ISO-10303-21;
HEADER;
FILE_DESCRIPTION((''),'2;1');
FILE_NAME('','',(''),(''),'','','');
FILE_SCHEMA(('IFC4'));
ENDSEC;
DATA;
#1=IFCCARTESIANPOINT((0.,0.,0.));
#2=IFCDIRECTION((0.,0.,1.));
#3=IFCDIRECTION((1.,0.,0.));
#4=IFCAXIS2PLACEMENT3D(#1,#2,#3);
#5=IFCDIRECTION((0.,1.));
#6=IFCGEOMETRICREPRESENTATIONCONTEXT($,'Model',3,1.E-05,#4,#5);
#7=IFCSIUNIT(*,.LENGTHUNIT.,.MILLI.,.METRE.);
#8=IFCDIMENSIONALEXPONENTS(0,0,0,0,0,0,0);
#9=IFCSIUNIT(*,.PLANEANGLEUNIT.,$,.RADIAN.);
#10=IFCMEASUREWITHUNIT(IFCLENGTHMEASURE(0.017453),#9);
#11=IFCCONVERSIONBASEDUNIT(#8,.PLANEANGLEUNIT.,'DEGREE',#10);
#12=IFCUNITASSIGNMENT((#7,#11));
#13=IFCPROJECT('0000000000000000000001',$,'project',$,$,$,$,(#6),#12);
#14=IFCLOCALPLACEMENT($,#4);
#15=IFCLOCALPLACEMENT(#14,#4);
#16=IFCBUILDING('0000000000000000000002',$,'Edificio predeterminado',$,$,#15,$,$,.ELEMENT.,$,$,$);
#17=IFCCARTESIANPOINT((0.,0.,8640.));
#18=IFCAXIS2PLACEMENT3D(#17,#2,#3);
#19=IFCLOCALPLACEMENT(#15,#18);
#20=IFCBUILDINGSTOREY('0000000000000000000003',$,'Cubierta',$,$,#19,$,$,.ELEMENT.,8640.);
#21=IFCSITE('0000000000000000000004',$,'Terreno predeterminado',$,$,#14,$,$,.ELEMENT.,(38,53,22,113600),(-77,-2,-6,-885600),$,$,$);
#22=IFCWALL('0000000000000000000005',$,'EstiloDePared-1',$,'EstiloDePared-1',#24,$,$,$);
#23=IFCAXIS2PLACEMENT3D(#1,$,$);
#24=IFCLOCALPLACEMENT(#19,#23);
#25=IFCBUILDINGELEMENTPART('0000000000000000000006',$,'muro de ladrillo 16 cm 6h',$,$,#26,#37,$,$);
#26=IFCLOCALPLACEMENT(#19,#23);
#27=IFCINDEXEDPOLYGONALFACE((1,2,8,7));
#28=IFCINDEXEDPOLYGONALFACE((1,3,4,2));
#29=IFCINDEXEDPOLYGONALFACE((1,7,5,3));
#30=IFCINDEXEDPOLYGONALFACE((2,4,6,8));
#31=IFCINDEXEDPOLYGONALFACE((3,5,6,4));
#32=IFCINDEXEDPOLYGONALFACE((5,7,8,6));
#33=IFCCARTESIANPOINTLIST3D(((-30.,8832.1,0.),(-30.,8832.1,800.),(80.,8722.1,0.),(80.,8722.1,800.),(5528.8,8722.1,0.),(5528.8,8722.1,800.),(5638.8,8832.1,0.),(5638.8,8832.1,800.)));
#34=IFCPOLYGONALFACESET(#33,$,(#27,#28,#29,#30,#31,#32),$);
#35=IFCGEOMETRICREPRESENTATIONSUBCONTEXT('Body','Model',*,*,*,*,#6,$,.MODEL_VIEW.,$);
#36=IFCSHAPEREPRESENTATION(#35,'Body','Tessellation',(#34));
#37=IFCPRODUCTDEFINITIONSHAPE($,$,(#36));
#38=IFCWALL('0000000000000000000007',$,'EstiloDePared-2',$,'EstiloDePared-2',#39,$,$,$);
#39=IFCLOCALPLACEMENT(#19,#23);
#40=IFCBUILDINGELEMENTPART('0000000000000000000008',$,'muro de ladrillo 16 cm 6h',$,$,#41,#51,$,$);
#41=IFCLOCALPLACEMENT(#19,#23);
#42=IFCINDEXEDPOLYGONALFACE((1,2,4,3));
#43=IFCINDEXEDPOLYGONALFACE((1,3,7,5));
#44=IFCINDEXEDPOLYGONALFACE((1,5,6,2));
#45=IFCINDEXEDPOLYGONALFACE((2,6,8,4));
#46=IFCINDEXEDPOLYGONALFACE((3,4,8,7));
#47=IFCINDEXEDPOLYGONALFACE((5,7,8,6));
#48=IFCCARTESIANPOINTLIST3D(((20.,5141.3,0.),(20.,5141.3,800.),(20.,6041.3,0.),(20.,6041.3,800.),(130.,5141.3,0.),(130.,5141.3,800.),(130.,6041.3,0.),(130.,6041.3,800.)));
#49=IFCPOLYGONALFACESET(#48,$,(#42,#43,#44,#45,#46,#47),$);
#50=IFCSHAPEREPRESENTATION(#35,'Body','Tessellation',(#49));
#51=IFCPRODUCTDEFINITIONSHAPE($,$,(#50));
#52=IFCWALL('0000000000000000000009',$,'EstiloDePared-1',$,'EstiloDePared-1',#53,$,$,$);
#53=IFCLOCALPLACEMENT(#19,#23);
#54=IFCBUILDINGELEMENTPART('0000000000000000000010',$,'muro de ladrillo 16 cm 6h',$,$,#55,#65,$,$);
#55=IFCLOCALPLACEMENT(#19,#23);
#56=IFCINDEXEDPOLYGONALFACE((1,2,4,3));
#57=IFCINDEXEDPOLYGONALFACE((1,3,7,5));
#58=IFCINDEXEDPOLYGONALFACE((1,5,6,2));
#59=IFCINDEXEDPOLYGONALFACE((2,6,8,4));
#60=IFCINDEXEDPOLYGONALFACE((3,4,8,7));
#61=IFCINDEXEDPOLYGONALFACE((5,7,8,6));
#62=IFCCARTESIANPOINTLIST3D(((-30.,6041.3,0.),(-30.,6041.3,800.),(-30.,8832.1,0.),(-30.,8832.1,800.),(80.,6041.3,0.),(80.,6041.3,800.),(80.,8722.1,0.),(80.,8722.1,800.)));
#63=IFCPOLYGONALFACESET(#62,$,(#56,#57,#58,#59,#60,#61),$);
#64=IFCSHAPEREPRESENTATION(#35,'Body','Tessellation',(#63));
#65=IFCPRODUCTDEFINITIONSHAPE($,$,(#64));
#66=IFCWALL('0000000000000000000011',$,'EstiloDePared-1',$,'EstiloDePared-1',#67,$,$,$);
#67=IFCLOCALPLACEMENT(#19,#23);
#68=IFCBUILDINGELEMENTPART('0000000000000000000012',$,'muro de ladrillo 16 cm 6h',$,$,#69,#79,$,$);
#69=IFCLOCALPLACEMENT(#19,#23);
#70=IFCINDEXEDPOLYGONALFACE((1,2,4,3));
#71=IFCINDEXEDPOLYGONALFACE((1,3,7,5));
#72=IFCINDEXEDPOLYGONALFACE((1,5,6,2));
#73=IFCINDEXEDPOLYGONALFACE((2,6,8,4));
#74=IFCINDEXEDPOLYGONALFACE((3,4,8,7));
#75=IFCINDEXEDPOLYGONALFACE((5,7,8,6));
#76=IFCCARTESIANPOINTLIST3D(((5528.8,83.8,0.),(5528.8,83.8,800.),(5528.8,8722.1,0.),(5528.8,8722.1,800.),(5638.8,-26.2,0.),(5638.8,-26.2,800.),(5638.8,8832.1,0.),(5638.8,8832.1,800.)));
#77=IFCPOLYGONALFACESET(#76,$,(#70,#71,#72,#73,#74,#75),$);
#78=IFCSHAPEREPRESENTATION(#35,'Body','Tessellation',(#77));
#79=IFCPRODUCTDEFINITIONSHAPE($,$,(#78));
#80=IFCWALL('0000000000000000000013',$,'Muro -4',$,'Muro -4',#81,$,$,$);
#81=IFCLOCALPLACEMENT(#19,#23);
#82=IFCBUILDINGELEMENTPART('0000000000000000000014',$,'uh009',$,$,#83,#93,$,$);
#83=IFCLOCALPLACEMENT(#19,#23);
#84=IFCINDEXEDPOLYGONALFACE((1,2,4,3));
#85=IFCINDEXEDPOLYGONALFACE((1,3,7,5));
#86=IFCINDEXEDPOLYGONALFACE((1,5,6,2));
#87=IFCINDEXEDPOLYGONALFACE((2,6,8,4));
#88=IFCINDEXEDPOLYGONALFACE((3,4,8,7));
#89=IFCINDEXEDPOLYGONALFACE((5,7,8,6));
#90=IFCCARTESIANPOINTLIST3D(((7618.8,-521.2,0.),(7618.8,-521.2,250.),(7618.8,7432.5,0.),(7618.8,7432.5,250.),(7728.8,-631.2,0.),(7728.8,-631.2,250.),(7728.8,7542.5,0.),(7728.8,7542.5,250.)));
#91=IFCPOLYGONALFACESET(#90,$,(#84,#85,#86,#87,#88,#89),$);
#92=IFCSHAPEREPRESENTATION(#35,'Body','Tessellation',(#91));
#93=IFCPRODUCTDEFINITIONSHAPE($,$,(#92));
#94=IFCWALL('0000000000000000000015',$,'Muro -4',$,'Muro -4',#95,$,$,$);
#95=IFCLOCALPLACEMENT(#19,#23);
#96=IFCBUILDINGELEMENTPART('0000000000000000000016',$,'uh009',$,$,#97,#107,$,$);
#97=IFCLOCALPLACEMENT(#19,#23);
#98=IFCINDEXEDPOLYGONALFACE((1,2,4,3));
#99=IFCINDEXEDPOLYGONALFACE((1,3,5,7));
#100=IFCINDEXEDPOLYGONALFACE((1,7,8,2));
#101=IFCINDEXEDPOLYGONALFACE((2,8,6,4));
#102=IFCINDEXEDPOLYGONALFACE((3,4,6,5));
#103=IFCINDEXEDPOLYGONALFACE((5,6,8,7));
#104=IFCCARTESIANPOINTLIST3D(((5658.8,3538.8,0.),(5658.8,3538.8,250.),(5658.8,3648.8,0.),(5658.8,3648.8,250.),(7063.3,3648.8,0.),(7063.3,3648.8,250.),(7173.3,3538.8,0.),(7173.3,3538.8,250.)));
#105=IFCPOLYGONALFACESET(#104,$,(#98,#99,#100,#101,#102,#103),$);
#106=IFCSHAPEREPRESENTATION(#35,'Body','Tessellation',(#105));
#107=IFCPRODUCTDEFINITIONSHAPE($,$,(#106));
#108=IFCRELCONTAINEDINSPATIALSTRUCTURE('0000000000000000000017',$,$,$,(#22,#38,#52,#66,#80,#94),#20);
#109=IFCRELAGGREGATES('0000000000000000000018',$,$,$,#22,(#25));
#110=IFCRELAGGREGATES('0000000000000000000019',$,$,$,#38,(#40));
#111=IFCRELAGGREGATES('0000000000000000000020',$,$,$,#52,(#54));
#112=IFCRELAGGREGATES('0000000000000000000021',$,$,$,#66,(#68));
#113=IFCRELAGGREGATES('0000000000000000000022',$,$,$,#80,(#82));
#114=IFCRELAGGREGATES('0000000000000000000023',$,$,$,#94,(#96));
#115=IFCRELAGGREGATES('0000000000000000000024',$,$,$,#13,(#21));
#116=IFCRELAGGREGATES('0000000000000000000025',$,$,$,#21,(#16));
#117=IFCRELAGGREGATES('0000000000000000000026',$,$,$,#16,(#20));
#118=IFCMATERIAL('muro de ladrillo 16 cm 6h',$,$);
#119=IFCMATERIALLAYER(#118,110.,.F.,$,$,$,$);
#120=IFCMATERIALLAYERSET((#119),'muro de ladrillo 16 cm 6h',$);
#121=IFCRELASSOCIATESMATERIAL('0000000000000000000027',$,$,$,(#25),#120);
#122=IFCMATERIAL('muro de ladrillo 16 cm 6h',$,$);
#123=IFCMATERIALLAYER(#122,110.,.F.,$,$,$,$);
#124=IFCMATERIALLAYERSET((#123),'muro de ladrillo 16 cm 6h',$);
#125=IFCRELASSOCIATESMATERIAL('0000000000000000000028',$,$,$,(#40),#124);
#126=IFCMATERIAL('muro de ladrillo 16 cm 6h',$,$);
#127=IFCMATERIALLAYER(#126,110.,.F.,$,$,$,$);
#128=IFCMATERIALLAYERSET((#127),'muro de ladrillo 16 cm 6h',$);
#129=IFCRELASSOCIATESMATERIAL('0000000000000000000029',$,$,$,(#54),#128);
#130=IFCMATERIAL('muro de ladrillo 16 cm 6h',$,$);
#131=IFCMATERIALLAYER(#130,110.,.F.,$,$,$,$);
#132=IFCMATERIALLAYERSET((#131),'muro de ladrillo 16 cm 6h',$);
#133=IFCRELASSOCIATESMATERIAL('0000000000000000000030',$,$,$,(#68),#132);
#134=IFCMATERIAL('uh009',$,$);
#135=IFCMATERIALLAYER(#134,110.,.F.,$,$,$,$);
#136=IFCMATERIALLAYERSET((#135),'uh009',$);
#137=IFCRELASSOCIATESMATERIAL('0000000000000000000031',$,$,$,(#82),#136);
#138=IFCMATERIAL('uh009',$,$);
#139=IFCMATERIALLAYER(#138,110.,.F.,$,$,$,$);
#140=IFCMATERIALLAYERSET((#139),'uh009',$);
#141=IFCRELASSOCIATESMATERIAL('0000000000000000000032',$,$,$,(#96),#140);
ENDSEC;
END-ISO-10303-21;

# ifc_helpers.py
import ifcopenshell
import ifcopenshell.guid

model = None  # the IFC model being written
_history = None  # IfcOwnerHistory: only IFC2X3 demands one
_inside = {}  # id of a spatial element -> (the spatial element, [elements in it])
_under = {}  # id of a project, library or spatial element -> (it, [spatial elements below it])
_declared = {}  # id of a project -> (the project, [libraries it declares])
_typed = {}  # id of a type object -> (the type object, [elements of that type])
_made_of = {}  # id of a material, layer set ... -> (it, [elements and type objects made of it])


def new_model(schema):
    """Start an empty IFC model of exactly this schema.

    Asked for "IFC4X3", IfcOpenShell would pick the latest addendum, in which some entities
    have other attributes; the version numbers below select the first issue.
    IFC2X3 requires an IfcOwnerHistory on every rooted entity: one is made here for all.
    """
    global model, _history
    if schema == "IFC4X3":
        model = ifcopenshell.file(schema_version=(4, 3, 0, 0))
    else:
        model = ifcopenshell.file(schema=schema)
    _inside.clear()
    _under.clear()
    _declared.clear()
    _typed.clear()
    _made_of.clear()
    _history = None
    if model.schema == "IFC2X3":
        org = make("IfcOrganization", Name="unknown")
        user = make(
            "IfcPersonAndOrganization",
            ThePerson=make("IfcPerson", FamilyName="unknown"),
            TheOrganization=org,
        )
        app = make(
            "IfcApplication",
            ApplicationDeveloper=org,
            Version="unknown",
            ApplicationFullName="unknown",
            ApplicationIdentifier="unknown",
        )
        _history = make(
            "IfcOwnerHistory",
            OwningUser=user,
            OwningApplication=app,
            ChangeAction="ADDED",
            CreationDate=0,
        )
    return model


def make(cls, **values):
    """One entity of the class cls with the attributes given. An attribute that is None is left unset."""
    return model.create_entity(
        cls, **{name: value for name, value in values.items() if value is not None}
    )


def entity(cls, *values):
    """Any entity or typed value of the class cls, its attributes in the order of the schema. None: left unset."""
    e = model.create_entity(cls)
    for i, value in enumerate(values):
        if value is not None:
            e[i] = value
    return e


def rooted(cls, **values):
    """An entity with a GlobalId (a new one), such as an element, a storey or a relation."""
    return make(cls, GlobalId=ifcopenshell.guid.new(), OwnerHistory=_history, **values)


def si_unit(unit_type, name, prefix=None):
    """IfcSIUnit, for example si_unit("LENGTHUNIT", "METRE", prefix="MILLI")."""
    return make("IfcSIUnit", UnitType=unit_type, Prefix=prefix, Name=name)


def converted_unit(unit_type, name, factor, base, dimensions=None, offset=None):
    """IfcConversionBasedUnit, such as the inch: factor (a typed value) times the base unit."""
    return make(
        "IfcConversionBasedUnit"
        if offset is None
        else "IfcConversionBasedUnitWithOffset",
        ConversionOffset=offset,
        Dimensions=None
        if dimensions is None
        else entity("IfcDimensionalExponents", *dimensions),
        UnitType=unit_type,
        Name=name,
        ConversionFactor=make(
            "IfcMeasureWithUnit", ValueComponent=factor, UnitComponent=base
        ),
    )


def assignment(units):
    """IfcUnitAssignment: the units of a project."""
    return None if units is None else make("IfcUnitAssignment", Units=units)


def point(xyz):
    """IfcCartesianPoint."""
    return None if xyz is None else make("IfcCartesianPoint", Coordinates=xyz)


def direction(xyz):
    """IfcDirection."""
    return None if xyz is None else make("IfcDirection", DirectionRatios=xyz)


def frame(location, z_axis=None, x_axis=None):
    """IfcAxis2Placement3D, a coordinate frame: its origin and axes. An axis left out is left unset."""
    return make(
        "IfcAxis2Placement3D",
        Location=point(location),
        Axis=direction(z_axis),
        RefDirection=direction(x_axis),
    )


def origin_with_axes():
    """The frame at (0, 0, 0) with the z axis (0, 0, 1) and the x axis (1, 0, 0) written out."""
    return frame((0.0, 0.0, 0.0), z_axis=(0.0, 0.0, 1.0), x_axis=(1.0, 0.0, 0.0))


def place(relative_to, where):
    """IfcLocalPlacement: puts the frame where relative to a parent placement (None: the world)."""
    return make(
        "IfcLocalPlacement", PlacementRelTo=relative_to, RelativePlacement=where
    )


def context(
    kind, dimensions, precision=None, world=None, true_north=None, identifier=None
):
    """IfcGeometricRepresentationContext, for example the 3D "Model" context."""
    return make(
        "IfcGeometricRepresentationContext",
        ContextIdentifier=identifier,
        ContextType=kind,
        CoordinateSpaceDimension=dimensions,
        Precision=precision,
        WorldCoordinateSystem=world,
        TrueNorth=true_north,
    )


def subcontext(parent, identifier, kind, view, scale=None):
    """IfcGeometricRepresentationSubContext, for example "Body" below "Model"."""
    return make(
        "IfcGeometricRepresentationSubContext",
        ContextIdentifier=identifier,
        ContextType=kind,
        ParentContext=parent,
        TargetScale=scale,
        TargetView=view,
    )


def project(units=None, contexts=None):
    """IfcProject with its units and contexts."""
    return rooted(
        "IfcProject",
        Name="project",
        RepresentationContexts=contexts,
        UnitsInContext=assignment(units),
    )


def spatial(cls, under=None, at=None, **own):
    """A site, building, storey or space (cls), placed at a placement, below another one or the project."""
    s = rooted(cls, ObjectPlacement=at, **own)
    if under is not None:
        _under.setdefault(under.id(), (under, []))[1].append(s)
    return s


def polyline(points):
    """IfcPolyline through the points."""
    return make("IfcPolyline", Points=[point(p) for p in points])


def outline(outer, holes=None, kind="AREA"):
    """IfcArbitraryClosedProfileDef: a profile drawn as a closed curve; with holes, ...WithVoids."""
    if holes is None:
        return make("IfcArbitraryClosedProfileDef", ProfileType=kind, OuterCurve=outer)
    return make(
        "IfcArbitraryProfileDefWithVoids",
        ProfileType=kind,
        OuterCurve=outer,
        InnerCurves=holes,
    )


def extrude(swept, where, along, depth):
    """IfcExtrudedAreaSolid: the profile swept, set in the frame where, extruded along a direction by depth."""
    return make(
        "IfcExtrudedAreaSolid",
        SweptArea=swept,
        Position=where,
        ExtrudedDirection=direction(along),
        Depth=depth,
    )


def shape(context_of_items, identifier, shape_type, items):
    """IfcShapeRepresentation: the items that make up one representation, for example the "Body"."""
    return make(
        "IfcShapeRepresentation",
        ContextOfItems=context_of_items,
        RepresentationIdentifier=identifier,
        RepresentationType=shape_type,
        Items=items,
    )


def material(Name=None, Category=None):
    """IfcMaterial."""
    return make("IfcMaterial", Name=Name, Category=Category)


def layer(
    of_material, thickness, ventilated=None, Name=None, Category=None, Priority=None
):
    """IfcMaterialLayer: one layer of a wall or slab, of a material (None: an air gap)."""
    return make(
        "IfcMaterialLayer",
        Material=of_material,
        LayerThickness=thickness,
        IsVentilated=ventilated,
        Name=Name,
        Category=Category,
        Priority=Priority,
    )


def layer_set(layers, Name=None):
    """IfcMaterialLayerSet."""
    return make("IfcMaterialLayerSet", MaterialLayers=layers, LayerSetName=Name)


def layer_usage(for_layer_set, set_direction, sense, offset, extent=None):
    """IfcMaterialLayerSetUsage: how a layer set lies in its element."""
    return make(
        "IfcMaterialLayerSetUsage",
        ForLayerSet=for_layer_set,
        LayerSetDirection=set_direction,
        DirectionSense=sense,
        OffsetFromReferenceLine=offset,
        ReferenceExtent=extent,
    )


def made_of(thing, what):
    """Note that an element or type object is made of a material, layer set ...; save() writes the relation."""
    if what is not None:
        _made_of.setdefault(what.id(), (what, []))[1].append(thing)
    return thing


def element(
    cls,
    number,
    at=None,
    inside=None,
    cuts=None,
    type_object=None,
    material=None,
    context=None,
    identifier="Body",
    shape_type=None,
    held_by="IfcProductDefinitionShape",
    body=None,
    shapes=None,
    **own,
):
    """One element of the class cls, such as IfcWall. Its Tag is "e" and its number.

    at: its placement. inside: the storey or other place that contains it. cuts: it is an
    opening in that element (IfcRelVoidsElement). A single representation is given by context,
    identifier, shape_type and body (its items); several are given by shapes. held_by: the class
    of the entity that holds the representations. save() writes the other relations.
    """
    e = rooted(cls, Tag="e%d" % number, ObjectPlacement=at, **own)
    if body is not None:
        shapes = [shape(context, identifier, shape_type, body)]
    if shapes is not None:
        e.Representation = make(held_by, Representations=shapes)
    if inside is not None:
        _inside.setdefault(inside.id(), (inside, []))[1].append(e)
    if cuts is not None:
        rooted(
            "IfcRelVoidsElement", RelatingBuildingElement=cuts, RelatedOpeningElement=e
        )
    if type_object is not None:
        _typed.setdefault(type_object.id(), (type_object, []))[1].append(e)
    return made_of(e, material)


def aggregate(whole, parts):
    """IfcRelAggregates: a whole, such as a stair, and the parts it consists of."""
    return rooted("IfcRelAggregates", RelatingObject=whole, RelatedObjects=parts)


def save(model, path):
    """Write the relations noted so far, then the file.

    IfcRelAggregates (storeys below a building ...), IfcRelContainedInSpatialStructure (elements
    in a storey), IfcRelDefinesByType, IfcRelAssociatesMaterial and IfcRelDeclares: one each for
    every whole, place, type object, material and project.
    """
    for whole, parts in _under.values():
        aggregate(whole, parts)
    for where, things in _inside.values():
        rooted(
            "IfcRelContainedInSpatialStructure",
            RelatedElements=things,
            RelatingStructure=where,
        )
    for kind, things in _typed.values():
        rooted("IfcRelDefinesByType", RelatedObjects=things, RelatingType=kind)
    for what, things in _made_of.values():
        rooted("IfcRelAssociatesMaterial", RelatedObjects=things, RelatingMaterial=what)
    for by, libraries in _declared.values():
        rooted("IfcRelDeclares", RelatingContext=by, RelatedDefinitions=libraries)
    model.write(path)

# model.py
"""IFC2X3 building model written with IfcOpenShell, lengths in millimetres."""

from ifc_helpers import new_model, entity, si_unit, converted_unit, direction, frame, origin_with_axes, place, context, subcontext, project, spatial, polyline, outline, extrude, material, layer, layer_set, layer_usage, element, aggregate, save


model = new_model("IFC2X3")

# Units and contexts
model_context = context("Model", 3, precision=1e-05, world=origin_with_axes(), true_north=direction((0.0, 1.0)))
body_context = subcontext(model_context, "Body", "Model", "MODEL_VIEW")
ifc_project = project(units=[si_unit("LENGTHUNIT", "METRE", prefix="MILLI"), converted_unit("PLANEANGLEUNIT", "DEGREE", entity("IfcLengthMeasure", 0.017453), si_unit("PLANEANGLEUNIT", "RADIAN"), dimensions=[0, 0, 0, 0, 0, 0, 0])], contexts=[model_context])

# Site, building, storey
site_placement = place(None, origin_with_axes())
site = spatial("IfcSite", under=ifc_project, at=site_placement, Name="Terreno predeterminado", CompositionType="ELEMENT", RefLatitude=(38, 53, 22, 113600), RefLongitude=(-77, -2, -6, -885600))
building_placement = place(site_placement, origin_with_axes())
building = spatial("IfcBuilding", under=site, at=building_placement, Name="Edificio predeterminado", CompositionType="ELEMENT")
storey_placement = place(building_placement, frame((0.0, 0.0, 8640.0), z_axis=(0.0, 0.0, 1.0), x_axis=(1.0, 0.0, 0.0)))
storey = spatial("IfcBuildingStorey", under=building, at=storey_placement, Name="Cubierta", CompositionType="ELEMENT", Elevation=8640.0)

# Wall, building element part
wall_1_placement = place(storey_placement, frame((25.0, 8777.1, 0.0), z_axis=(0.0, 0.0, 1.0), x_axis=(1.0, 0.0, 0.0)))
wall_1 = element("IfcWall", 1, at=wall_1_placement, inside=storey, Name="EstiloDePared-1", ObjectType="EstiloDePared-1")
ifc_material_1 = material(Name="muro de ladrillo 16 cm 6h")
ifc_layer_1 = layer(ifc_material_1, 110.0, ventilated=False)
ifc_layer_set_1 = layer_set([ifc_layer_1], Name="muro de ladrillo 16 cm 6h")
ifc_layer_usage_1 = layer_usage(ifc_layer_set_1, "AXIS2", "NEGATIVE", -55.0)
building_element_part_1_placement = place(wall_1_placement, origin_with_axes())
building_element_part_1 = element("IfcBuildingElementPart", 2, at=building_element_part_1_placement, material=ifc_layer_usage_1, Name="muro de ladrillo 16 cm 6h", context=body_context, shape_type="SweptSolid", body=[
    extrude(outline(polyline([(5613.8, 55.0), (5503.8, -55.0), (55.0, -55.0), (-55.0, 55.0), (5613.8, 55.0)])), origin_with_axes(), (0.0, 0.0, 1.0), 800.0),
])
aggregate(wall_1, [building_element_part_1])

# Walls, building element parts
wall_2_placement = place(storey_placement, frame((75.0, 5141.3, 0.0), z_axis=(0.0, 0.0, 1.0), x_axis=(0.0, 1.0, 0.0)))
wall_2 = element("IfcWall", 3, at=wall_2_placement, inside=storey, Name="EstiloDePared-2", ObjectType="EstiloDePared-2")
ifc_material_2 = material(Name="muro de ladrillo 16 cm 6h")
ifc_layer_2 = layer(ifc_material_2, 110.0, ventilated=False)
ifc_layer_set_2 = layer_set([ifc_layer_2], Name="muro de ladrillo 16 cm 6h")
ifc_layer_usage_2 = layer_usage(ifc_layer_set_2, "AXIS2", "NEGATIVE", -55.0)
building_element_part_2_placement = place(wall_2_placement, origin_with_axes())
building_element_part_2 = element("IfcBuildingElementPart", 4, at=building_element_part_2_placement, material=ifc_layer_usage_2, Name="muro de ladrillo 16 cm 6h", context=body_context, shape_type="SweptSolid", body=[
    extrude(outline(polyline([(900.0, 55.0), (900.0, -55.0), (0.0, -55.0), (0.0, 55.0), (900.0, 55.0)])), origin_with_axes(), (0.0, 0.0, 1.0), 800.0),
])
aggregate(wall_2, [building_element_part_2])
wall_3_placement = place(storey_placement, frame((25.0, 6041.3, 0.0), z_axis=(0.0, 0.0, 1.0), x_axis=(0.0, 1.0, 0.0)))
wall_3 = element("IfcWall", 5, at=wall_3_placement, inside=storey, Name="EstiloDePared-1", ObjectType="EstiloDePared-1")
ifc_material_3 = material(Name="muro de ladrillo 16 cm 6h")
ifc_layer_3 = layer(ifc_material_3, 110.0, ventilated=False)
ifc_layer_set_3 = layer_set([ifc_layer_3], Name="muro de ladrillo 16 cm 6h")
ifc_layer_usage_3 = layer_usage(ifc_layer_set_3, "AXIS2", "NEGATIVE", -55.0)
building_element_part_3_placement = place(wall_3_placement, origin_with_axes())
building_element_part_3 = element("IfcBuildingElementPart", 6, at=building_element_part_3_placement, material=ifc_layer_usage_3, Name="muro de ladrillo 16 cm 6h", context=body_context, shape_type="SweptSolid", body=[
    extrude(outline(polyline([(2790.8, 55.0), (2680.8, -55.0), (0.0, -55.0), (0.0, 55.0), (2790.8, 55.0)])), origin_with_axes(), (0.0, 0.0, 1.0), 800.0),
])
aggregate(wall_3, [building_element_part_3])
wall_4_placement = place(storey_placement, frame((5583.8, 8777.1, 0.0), z_axis=(0.0, 0.0, 1.0), x_axis=(0.0, -1.0, 0.0)))
wall_4 = element("IfcWall", 7, at=wall_4_placement, inside=storey, Name="EstiloDePared-1", ObjectType="EstiloDePared-1")
ifc_material_4 = material(Name="muro de ladrillo 16 cm 6h")
ifc_layer_4 = layer(ifc_material_4, 110.0, ventilated=False)
ifc_layer_set_4 = layer_set([ifc_layer_4], Name="muro de ladrillo 16 cm 6h")
ifc_layer_usage_4 = layer_usage(ifc_layer_set_4, "AXIS2", "NEGATIVE", -55.0)
building_element_part_4_placement = place(wall_4_placement, origin_with_axes())
building_element_part_4 = element("IfcBuildingElementPart", 8, at=building_element_part_4_placement, material=ifc_layer_usage_4, Name="muro de ladrillo 16 cm 6h", context=body_context, shape_type="SweptSolid", body=[
    extrude(outline(polyline([(8803.3, 55.0), (8693.3, -55.0), (55.0, -55.0), (-55.0, 55.0), (8803.3, 55.0)])), origin_with_axes(), (0.0, 0.0, 1.0), 800.0),
])
aggregate(wall_4, [building_element_part_4])
wall_5_placement = place(storey_placement, frame((7673.8, 7487.5, 0.0), z_axis=(0.0, 0.0, 1.0), x_axis=(0.0, -1.0, 0.0)))
wall_5 = element("IfcWall", 9, at=wall_5_placement, inside=storey, Name="Muro -4", ObjectType="Muro -4")
ifc_material_5 = material(Name="uh009")
ifc_layer_5 = layer(ifc_material_5, 110.0, ventilated=False)
ifc_layer_set_5 = layer_set([ifc_layer_5], Name="uh009")
ifc_layer_usage_5 = layer_usage(ifc_layer_set_5, "AXIS2", "NEGATIVE", -55.0)
building_element_part_5_placement = place(wall_5_placement, origin_with_axes())
building_element_part_5 = element("IfcBuildingElementPart", 10, at=building_element_part_5_placement, material=ifc_layer_usage_5, Name="uh009", context=body_context, shape_type="SweptSolid", body=[
    extrude(outline(polyline([(8118.7, 55.0), (8008.7, -55.0), (55.0, -55.0), (-55.0, 55.0), (8118.7, 55.0)])), origin_with_axes(), (0.0, 0.0, 1.0), 250.0),
])
aggregate(wall_5, [building_element_part_5])
wall_6_placement = place(storey_placement, frame((7118.3, 3593.8, 0.0), z_axis=(0.0, 0.0, 1.0), x_axis=(-1.0, 0.0, 0.0)))
wall_6 = element("IfcWall", 11, at=wall_6_placement, inside=storey, Name="Muro -4", ObjectType="Muro -4")
ifc_material_6 = material(Name="uh009")
ifc_layer_6 = layer(ifc_material_6, 110.0, ventilated=False)
ifc_layer_set_6 = layer_set([ifc_layer_6], Name="uh009")
ifc_layer_usage_6 = layer_usage(ifc_layer_set_6, "AXIS2", "NEGATIVE", -55.0)
building_element_part_6_placement = place(wall_6_placement, origin_with_axes())
building_element_part_6 = element("IfcBuildingElementPart", 12, at=building_element_part_6_placement, material=ifc_layer_usage_6, Name="uh009", context=body_context, shape_type="SweptSolid", body=[
    extrude(outline(polyline([(1459.4, 55.0), (1459.4, -55.0), (55.0, -55.0), (-55.0, 55.0), (1459.4, 55.0)])), origin_with_axes(), (0.0, 0.0, 1.0), 250.0),
])
aggregate(wall_6, [building_element_part_6])

save(model, "model.ifc")
